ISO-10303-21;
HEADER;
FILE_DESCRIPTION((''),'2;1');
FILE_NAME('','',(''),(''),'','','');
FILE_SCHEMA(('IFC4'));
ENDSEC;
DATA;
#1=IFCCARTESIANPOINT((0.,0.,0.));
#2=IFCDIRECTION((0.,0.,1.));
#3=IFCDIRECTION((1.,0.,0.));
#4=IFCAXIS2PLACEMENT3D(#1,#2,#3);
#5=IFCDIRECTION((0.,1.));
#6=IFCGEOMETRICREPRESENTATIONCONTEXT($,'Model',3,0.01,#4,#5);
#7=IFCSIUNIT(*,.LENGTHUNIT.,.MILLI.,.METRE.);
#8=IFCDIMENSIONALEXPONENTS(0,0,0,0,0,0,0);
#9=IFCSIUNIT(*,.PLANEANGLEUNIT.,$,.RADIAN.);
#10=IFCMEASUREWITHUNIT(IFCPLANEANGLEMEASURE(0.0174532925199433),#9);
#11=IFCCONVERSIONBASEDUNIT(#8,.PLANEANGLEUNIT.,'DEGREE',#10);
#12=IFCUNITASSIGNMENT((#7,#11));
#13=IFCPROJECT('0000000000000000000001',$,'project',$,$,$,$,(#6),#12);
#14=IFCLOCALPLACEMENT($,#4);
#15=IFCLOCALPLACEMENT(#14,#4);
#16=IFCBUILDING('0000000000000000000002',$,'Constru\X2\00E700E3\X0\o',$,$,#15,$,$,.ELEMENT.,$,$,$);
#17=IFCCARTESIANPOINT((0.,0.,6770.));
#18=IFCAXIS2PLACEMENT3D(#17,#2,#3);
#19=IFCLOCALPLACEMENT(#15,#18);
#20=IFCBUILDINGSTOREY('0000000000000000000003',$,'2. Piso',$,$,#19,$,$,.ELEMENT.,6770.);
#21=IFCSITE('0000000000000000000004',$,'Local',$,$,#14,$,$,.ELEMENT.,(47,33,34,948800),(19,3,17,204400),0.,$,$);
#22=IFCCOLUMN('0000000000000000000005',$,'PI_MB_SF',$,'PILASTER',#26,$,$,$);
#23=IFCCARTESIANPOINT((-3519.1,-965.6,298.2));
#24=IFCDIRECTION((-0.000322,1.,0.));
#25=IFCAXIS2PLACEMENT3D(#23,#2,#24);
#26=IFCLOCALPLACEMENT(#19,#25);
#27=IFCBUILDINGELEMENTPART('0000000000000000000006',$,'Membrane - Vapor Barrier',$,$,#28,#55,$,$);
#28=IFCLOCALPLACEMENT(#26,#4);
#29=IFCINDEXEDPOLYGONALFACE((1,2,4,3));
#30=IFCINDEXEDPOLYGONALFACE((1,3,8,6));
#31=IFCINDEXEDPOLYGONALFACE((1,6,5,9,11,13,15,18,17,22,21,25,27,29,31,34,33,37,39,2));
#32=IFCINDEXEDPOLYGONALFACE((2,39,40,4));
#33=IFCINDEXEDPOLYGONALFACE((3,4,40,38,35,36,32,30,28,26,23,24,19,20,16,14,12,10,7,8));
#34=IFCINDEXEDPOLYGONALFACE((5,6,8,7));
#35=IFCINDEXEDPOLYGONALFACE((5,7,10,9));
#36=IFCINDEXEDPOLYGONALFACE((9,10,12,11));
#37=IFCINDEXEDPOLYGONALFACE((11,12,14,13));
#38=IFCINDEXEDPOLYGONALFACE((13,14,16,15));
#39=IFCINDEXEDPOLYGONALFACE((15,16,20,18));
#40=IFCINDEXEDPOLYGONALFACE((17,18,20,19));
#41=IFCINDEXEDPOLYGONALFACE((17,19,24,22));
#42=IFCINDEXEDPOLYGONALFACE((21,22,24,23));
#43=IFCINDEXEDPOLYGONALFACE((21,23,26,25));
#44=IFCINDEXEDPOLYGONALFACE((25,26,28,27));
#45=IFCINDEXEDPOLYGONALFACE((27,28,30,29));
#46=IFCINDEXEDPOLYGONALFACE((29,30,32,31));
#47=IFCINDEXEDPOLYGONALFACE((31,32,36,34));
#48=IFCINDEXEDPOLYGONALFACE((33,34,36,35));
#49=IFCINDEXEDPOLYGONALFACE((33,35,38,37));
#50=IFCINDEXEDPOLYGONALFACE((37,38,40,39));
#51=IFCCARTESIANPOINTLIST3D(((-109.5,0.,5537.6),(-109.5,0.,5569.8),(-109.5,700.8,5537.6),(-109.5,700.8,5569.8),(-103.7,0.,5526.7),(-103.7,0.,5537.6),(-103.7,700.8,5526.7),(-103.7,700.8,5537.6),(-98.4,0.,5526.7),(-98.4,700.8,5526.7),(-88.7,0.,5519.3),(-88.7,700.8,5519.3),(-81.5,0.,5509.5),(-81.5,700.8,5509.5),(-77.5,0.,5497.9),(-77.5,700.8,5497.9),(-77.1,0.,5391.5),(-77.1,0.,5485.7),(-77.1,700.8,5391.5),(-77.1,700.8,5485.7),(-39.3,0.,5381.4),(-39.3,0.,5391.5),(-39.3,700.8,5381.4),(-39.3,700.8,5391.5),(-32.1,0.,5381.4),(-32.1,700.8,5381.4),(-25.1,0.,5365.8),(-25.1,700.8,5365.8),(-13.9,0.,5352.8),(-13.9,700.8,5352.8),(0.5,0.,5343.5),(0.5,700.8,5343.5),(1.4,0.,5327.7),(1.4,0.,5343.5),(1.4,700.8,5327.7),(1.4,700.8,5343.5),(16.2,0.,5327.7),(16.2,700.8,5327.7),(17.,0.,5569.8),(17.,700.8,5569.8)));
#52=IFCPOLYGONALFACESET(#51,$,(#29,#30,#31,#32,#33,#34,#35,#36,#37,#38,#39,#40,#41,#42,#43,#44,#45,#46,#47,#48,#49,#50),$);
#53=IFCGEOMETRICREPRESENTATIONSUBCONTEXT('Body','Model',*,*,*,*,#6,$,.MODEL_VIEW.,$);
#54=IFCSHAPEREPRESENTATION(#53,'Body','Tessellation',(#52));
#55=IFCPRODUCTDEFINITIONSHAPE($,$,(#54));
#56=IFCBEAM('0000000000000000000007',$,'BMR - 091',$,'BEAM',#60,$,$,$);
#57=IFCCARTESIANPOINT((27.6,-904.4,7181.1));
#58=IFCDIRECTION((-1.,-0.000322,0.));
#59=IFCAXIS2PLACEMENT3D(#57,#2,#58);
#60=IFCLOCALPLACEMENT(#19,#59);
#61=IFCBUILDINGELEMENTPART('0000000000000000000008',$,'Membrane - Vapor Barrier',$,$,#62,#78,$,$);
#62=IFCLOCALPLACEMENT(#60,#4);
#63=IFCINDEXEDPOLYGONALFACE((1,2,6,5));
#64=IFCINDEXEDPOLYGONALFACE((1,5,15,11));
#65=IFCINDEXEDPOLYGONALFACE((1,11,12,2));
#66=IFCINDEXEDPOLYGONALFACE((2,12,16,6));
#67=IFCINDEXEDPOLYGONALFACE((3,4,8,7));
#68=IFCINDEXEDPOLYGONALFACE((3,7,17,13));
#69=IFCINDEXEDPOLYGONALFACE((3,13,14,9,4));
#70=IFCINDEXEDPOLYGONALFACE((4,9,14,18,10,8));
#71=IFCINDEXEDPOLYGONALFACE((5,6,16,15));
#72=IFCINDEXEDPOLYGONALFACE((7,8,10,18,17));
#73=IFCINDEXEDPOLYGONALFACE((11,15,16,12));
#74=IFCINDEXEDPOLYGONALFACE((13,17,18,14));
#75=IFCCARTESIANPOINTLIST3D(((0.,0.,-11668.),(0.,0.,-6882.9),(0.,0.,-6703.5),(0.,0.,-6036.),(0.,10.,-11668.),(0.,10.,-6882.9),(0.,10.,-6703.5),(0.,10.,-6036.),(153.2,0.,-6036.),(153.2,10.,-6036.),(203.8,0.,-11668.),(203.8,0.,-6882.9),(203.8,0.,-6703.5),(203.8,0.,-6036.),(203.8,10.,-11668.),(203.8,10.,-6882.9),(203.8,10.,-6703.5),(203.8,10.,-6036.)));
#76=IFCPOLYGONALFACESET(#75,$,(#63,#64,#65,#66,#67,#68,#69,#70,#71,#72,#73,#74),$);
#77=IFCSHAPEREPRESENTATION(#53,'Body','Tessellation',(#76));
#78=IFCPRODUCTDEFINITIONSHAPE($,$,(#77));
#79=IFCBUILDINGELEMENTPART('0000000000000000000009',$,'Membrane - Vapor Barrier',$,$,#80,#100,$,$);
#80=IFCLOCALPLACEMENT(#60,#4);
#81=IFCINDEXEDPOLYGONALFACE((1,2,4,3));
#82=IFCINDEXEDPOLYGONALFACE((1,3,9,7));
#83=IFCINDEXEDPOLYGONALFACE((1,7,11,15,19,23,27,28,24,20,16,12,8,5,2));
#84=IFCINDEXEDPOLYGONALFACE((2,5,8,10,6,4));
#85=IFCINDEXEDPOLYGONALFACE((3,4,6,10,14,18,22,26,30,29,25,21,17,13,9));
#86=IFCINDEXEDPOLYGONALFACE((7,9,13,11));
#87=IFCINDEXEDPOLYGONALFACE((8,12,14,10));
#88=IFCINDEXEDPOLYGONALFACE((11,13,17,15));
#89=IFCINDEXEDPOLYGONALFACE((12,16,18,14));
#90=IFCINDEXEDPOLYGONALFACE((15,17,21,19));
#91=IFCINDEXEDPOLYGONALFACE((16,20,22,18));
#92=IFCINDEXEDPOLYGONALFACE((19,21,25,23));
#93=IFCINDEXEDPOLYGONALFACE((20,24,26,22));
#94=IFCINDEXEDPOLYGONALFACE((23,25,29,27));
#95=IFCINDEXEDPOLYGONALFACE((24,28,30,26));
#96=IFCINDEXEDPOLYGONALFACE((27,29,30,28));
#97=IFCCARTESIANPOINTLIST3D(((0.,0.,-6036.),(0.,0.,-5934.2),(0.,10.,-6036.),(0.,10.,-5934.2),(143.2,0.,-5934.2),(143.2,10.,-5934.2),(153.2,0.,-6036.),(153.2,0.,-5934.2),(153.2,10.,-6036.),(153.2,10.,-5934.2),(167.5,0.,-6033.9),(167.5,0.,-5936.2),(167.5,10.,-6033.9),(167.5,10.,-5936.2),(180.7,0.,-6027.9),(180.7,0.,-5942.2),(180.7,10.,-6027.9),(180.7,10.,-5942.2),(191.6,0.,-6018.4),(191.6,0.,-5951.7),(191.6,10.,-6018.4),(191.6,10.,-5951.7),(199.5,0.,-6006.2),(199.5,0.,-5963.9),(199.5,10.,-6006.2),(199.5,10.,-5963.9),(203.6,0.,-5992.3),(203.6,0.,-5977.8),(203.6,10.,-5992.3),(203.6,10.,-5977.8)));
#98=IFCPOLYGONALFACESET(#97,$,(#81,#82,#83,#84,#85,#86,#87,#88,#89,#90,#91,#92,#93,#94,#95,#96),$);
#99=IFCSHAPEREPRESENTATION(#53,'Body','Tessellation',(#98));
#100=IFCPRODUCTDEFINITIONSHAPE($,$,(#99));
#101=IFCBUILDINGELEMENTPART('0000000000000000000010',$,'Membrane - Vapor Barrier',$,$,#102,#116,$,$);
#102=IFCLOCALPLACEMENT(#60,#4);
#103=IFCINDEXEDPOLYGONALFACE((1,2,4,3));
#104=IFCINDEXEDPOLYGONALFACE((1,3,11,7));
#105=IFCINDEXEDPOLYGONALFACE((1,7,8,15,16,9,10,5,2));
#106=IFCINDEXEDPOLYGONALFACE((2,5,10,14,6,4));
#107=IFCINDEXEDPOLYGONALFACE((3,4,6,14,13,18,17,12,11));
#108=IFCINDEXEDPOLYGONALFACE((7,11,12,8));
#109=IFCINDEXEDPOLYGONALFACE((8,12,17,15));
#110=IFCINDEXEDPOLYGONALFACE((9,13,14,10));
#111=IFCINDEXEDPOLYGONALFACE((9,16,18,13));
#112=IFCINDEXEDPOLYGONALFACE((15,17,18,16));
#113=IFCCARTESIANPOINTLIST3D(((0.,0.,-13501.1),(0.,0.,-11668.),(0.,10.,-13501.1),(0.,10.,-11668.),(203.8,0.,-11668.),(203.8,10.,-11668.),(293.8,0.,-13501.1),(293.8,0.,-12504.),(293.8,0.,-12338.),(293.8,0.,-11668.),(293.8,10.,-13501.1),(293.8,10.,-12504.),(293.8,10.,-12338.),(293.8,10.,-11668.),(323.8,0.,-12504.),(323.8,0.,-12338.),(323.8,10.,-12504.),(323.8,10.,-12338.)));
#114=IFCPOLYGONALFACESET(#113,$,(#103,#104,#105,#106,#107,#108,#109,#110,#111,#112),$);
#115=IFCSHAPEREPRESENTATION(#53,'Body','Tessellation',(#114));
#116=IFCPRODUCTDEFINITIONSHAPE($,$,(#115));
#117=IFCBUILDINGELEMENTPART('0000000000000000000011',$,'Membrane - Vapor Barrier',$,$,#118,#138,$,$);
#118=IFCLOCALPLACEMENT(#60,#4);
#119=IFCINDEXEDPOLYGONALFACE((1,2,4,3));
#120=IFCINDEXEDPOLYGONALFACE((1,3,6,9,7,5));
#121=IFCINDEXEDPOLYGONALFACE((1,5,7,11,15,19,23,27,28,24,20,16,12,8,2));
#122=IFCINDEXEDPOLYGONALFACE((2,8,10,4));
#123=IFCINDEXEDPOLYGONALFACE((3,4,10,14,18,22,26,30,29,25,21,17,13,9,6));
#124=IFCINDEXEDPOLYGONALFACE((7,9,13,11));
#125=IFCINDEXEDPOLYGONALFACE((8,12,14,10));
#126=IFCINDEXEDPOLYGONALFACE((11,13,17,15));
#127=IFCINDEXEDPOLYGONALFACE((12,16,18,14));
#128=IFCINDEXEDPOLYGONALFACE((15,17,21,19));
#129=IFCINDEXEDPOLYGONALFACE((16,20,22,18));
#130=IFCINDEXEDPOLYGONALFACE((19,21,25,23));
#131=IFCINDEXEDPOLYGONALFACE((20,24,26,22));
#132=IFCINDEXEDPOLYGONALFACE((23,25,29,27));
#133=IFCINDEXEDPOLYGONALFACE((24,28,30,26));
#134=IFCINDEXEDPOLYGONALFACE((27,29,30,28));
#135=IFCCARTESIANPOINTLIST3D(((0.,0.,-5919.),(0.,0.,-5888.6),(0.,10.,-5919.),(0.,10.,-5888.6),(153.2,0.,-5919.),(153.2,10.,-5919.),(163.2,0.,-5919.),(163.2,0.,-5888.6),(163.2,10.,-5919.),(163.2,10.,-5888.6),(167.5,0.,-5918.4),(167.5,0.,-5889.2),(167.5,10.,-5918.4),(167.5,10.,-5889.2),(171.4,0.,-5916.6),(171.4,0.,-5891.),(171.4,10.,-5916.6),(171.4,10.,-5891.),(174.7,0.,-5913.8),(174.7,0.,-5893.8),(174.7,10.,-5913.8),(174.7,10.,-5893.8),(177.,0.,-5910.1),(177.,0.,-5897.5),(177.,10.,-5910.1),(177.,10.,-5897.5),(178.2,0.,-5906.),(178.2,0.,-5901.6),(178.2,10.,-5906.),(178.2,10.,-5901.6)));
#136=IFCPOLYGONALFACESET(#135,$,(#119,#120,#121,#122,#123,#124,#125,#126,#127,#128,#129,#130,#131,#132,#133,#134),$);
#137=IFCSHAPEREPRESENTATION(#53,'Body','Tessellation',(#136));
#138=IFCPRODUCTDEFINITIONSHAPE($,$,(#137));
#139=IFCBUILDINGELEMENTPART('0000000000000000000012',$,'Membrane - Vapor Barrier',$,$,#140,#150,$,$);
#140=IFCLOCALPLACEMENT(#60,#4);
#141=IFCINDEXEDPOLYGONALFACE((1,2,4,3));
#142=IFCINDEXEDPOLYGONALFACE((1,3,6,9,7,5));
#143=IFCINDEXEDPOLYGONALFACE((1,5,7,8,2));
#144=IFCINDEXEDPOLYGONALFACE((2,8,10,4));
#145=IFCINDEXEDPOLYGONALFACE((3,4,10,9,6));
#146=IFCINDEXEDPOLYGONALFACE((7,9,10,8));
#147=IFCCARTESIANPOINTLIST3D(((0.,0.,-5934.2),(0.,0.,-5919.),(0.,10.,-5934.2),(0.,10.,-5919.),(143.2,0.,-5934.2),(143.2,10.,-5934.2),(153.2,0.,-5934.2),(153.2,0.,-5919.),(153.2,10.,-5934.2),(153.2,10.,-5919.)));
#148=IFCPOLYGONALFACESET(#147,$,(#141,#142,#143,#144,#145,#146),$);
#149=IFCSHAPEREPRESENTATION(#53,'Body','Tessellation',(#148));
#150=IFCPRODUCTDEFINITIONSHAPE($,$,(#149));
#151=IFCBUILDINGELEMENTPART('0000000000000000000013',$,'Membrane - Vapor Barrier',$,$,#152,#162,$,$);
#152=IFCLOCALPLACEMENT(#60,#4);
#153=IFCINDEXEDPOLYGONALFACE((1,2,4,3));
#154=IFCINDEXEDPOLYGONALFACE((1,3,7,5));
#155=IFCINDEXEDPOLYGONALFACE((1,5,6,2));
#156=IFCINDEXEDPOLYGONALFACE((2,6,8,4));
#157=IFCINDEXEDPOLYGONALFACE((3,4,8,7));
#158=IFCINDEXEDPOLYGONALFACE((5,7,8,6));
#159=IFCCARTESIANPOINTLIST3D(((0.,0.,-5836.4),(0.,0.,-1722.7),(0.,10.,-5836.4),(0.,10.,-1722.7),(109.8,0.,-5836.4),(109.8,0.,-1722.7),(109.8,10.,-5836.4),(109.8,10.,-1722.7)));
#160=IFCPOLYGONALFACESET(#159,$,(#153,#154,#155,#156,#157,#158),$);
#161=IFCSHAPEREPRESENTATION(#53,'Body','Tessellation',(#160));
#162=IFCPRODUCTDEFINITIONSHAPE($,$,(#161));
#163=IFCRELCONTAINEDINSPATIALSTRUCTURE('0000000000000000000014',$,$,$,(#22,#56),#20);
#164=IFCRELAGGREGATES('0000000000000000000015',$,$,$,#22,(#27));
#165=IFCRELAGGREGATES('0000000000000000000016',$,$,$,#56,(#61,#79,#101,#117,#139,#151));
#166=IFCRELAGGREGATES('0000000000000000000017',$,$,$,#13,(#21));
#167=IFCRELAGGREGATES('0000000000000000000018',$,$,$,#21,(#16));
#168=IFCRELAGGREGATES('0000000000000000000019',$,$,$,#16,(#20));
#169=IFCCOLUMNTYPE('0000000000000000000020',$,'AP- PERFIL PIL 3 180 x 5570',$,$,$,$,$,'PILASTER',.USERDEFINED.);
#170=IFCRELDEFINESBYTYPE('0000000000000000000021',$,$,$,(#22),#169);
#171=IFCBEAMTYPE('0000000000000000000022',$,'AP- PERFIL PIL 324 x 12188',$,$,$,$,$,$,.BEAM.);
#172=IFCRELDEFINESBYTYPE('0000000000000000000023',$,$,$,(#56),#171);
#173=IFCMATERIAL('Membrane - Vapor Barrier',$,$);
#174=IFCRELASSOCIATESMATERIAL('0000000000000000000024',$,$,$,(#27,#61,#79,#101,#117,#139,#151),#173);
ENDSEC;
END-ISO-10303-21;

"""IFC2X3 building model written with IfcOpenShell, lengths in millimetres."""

from ifc_helpers import new_model, entity, si_unit, converted_unit, point, direction, frame, frame_2d, origin_with_axes, place, context, subcontext, project, spatial, polyline, circle_curve, parameter, trimmed, segment, composite_curve, outline, composite_profile, extrude, material, type_object, element, aggregate, save


model = new_model("IFC2X3")

# Units and contexts
model_context = context("Model", 3, precision=0.01, world=origin_with_axes(), true_north=direction((0.0, 1.0)))
body_context = subcontext(model_context, "Body", "Model", "MODEL_VIEW")
ifc_project = project(units=[si_unit("LENGTHUNIT", "METRE", prefix="MILLI"), converted_unit("PLANEANGLEUNIT", "DEGREE", entity("IfcPlaneAngleMeasure", 0.0174532925199433), si_unit("PLANEANGLEUNIT", "RADIAN"), dimensions=[0, 0, 0, 0, 0, 0, 0])], contexts=[model_context])

# Site, building, storey
site_placement = place(None, origin_with_axes())
site = spatial("IfcSite", under=ifc_project, at=site_placement, Name="Local", CompositionType="ELEMENT", RefLatitude=(47, 33, 34, 948800), RefLongitude=(19, 3, 17, 204400), RefElevation=0.0)
building_placement = place(site_placement, origin_with_axes())
building = spatial("IfcBuilding", under=site, at=building_placement, Name="Construção", CompositionType="ELEMENT")
storey_placement = place(building_placement, frame((0.0, 0.0, 6770.0), z_axis=(0.0, 0.0, 1.0), x_axis=(1.0, 0.0, 0.0)))
storey = spatial("IfcBuildingStorey", under=building, at=storey_placement, Name="2. Piso", CompositionType="ELEMENT", Elevation=6770.0)

# Column, building element part
column_type = type_object("IfcColumnType", Name="AP- PERFIL PIL 3 180 x 5570", ElementType="PILASTER", PredefinedType="USERDEFINED")
ifc_material = material(Name="Membrane - Vapor Barrier")
column_1_placement = place(storey_placement, frame((-3519.1, -965.6, 298.2), z_axis=(0.0, 0.0, 1.0), x_axis=(-0.000322, 1.0, 0.0)))
column_1 = element("IfcColumn", 1, at=column_1_placement, inside=storey, type_object=column_type, Name="PI_MB_SF", ObjectType="PILASTER")
building_element_part_1_placement = place(column_1_placement, origin_with_axes())
building_element_part_1 = element("IfcBuildingElementPart", 2, at=building_element_part_1_placement, material=ifc_material, Name="Membrane - Vapor Barrier", context=body_context, shape_type="SweptSolid", body=[
    extrude(outline(composite_curve([segment(polyline([(-16.2, 5327.7), (-1.4, 5327.7), (-1.4, 5343.5), (-0.5, 5343.5)]), True, "CONTINUOUS"), segment(trimmed(circle_curve(frame_2d((-25.0, 5397.6), x_axis=(0.411627, -0.911352)), 59.4), [point((-0.5, 5343.5)), parameter(0.0)], [point((32.1, 5381.4)), parameter(49.79606)], True, "CARTESIAN"), True, "CONTINUOUS"), segment(polyline([(32.1, 5381.4), (39.3, 5381.4), (39.3, 5391.5), (77.1, 5391.5), (77.1, 5485.7)]), True, "CONTINUOUS"), segment(trimmed(circle_curve(frame_2d((118.3, 5490.3), x_axis=(-0.480333, 0.877086)), 41.5), [point((77.1, 5485.7)), parameter(67.594129)], [point((98.4, 5526.7)), parameter(0.0)], False, "CARTESIAN"), True, "CONTINUOUS"), segment(polyline([(98.4, 5526.7), (103.7, 5526.7), (103.7, 5537.6), (109.5, 5537.6), (109.5, 5569.8), (-17.0, 5569.8), (-16.2, 5327.7)]), True, "CONTINUOUS")], self_intersect=False)), frame((0.0, 700.8, 0.0), z_axis=(0.0, 1.0, 0.0), x_axis=(-1.0, 0.0, 0.0)), (0.0, 0.0, -1.0), 700.8),
])
aggregate(column_1, [building_element_part_1])

# Beam, building element parts
beam_type = type_object("IfcBeamType", Name="AP- PERFIL PIL 324 x 12188", PredefinedType="BEAM")
beam_placement = place(storey_placement, frame((27.6, -904.4, 7181.1), z_axis=(0.0, 0.0, 1.0), x_axis=(-1.0, -0.000322, 0.0)))
beam = element("IfcBeam", 3, at=beam_placement, inside=storey, type_object=beam_type, Name="BMR - 091", ObjectType="BEAM")
building_element_part_2_placement = place(beam_placement, origin_with_axes())
building_element_part_2 = element("IfcBuildingElementPart", 4, at=building_element_part_2_placement, material=ifc_material, Name="Membrane - Vapor Barrier", context=body_context, shape_type="SweptSolid", body=[
    extrude(composite_profile([outline(polyline([(0.0, -11668.0), (203.8, -11668.0), (203.8, -6882.9), (0.0, -6882.9), (0.0, -11668.0)])), outline(polyline([(0.0, -6703.5), (203.8, -6703.5), (203.8, -6036.0), (153.2, -6036.0), (0.0, -6036.0), (0.0, -6703.5)]))]), frame((0.0, 10.0, 0.0), z_axis=(0.0, -1.0, 0.0), x_axis=(1.0, 0.0, 0.0)), (0.0, 0.0, 1.0), 10.0),
])
building_element_part_3_placement = place(beam_placement, origin_with_axes())
building_element_part_3 = element("IfcBuildingElementPart", 5, at=building_element_part_3_placement, material=ifc_material, Name="Membrane - Vapor Barrier", context=body_context, shape_type="SweptSolid", body=[
    extrude(outline(composite_curve([segment(polyline([(0.0, -5934.2), (0.0, -6036.0), (153.2, -6036.0)]), True, "CONTINUOUS"), segment(trimmed(circle_curve(frame_2d((153.2, -5985.1), x_axis=(0.0, -1.0)), 50.9), [point((153.2, -6036.0)), parameter(0.0)], [point((153.2, -5934.2)), parameter(180.0)], True, "CARTESIAN"), True, "CONTINUOUS"), segment(polyline([(153.2, -5934.2), (143.2, -5934.2), (0.0, -5934.2)]), True, "CONTINUOUS")], self_intersect=False)), frame((0.0, 10.0, 0.0), z_axis=(0.0, -1.0, 0.0), x_axis=(1.0, 0.0, 0.0)), (0.0, 0.0, 1.0), 10.0),
])
building_element_part_4_placement = place(beam_placement, origin_with_axes())
building_element_part_4 = element("IfcBuildingElementPart", 6, at=building_element_part_4_placement, material=ifc_material, Name="Membrane - Vapor Barrier", context=body_context, shape_type="SweptSolid", body=[
    extrude(outline(polyline([(0.0, -13501.1), (293.8, -13501.1), (293.8, -12504.0), (323.8, -12504.0), (323.8, -12338.0), (293.8, -12338.0), (293.8, -11668.0), (203.8, -11668.0), (0.0, -11668.0), (0.0, -13501.1)])), frame((0.0, 10.0, 0.0), z_axis=(0.0, -1.0, 0.0), x_axis=(1.0, 0.0, 0.0)), (0.0, 0.0, 1.0), 10.0),
])
building_element_part_5_placement = place(beam_placement, origin_with_axes())
building_element_part_5 = element("IfcBuildingElementPart", 7, at=building_element_part_5_placement, material=ifc_material, Name="Membrane - Vapor Barrier", context=body_context, shape_type="SweptSolid", body=[
    extrude(outline(composite_curve([segment(polyline([(0.0, -5888.6), (0.0, -5919.0), (153.2, -5919.0), (163.2, -5919.0)]), True, "CONTINUOUS"), segment(trimmed(circle_curve(frame_2d((163.2, -5903.8), x_axis=(0.0, -1.0)), 15.2), [point((163.2, -5919.0)), parameter(0.0)], [point((163.2, -5888.6)), parameter(180.0)], True, "CARTESIAN"), True, "CONTINUOUS"), segment(polyline([(163.2, -5888.6), (0.0, -5888.6)]), True, "CONTINUOUS")], self_intersect=False)), frame((0.0, 10.0, 0.0), z_axis=(0.0, -1.0, 0.0), x_axis=(1.0, 0.0, 0.0)), (0.0, 0.0, 1.0), 10.0),
])
building_element_part_6_placement = place(beam_placement, origin_with_axes())
building_element_part_6 = element("IfcBuildingElementPart", 8, at=building_element_part_6_placement, material=ifc_material, Name="Membrane - Vapor Barrier", context=body_context, shape_type="SweptSolid", body=[
    extrude(outline(polyline([(0.0, -5934.2), (143.2, -5934.2), (153.2, -5934.2), (153.2, -5919.0), (0.0, -5919.0), (0.0, -5934.2)])), frame((0.0, 10.0, 0.0), z_axis=(0.0, -1.0, 0.0), x_axis=(1.0, 0.0, 0.0)), (0.0, 0.0, 1.0), 10.0),
])
building_element_part_7_placement = place(beam_placement, origin_with_axes())
building_element_part_7 = element("IfcBuildingElementPart", 9, at=building_element_part_7_placement, material=ifc_material, Name="Membrane - Vapor Barrier", context=body_context, shape_type="SweptSolid", body=[
    extrude(outline(polyline([(109.8, -1722.7), (0.0, -1722.7), (0.0, -5836.4), (109.8, -5836.4), (109.8, -1722.7)])), frame((0.0, 10.0, 0.0), z_axis=(0.0, -1.0, 0.0), x_axis=(1.0, 0.0, 0.0)), (0.0, 0.0, 1.0), 10.0),
])
aggregate(beam, [building_element_part_2, building_element_part_3, building_element_part_4, building_element_part_5, building_element_part_6, building_element_part_7])

save(model, "model.ifc")
